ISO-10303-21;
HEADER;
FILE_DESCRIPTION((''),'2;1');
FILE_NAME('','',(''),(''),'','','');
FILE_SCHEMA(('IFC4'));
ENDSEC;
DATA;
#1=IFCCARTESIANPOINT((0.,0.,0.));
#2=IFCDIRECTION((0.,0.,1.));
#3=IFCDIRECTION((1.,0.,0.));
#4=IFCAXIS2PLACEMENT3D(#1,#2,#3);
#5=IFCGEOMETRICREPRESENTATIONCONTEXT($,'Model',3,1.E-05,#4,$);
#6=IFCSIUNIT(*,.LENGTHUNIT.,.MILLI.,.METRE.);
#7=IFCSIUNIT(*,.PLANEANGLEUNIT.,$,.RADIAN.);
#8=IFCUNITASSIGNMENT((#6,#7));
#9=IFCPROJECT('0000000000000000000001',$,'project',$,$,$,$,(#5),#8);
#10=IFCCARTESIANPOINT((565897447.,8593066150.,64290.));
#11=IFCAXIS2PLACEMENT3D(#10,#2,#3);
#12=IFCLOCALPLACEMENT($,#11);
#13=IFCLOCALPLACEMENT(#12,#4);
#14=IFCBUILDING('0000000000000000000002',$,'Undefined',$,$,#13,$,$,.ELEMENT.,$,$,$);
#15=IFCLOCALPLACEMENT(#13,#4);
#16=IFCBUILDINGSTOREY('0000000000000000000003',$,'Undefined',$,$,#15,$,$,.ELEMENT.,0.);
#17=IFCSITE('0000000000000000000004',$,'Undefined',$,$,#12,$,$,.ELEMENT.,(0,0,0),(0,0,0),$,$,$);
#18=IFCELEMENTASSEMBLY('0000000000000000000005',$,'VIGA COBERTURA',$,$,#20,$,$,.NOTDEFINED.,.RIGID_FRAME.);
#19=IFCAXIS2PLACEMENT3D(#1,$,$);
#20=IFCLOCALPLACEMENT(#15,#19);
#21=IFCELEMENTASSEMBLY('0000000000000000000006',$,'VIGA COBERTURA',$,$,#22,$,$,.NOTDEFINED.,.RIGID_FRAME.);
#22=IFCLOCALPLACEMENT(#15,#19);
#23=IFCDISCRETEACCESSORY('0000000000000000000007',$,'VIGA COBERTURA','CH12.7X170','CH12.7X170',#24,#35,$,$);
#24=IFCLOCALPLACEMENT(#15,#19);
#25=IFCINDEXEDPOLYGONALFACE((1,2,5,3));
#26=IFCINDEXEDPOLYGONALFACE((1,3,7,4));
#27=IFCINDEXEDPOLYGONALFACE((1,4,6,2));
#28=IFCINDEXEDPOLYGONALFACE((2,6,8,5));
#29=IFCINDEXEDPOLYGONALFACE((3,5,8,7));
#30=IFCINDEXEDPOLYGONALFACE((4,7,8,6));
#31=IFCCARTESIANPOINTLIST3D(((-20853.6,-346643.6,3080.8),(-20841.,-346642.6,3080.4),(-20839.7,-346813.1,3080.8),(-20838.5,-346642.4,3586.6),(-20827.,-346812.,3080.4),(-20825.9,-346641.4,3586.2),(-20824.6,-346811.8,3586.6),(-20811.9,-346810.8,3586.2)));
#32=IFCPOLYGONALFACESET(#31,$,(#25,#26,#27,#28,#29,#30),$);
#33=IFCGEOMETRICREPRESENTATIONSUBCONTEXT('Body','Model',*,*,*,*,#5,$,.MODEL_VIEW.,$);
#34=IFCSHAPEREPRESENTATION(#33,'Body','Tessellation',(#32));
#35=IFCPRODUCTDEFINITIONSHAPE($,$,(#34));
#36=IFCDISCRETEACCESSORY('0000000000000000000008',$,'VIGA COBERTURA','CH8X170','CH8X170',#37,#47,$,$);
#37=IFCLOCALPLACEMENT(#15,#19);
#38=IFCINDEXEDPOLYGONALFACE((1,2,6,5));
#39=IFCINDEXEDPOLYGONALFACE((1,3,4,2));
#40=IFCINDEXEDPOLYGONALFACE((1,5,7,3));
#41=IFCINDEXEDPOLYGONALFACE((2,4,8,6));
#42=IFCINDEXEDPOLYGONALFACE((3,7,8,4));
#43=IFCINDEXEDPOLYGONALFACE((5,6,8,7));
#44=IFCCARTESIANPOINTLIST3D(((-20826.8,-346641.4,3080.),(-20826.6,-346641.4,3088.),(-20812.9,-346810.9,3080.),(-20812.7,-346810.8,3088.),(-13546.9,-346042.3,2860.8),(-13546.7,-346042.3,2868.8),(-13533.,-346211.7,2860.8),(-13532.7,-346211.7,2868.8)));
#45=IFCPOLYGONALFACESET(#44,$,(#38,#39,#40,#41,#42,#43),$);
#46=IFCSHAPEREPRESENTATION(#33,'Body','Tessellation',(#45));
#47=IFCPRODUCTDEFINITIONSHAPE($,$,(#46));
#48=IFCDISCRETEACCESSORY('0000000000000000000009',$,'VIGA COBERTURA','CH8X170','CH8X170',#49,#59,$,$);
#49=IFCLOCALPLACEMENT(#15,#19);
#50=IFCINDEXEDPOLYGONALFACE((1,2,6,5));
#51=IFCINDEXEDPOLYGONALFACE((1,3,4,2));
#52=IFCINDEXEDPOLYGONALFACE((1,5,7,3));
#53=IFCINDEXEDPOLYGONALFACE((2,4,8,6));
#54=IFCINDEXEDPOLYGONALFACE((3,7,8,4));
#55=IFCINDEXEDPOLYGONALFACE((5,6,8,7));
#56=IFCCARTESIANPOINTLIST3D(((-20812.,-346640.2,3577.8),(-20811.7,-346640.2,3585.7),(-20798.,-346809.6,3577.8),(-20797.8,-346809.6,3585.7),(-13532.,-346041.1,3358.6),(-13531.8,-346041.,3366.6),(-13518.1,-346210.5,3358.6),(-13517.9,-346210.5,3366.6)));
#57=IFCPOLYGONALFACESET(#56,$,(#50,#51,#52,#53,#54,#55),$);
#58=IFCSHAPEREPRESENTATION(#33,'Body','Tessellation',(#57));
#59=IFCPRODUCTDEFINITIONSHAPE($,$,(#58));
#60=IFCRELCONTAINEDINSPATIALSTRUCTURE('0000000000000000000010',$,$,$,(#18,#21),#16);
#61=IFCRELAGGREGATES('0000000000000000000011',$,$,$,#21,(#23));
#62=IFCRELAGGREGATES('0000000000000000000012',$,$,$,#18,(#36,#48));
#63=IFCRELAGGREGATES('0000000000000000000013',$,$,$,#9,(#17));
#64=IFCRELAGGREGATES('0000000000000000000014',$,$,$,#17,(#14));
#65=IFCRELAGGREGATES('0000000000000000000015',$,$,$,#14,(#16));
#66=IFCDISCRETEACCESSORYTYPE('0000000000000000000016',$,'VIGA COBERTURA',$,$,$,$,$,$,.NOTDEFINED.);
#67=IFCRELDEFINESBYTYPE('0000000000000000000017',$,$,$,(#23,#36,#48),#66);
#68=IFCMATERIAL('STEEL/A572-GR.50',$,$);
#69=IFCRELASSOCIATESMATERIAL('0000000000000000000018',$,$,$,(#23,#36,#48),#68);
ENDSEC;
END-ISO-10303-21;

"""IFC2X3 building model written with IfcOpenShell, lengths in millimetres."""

from ifc_helpers import new_model, si_unit, frame, origin_with_axes, origin_2d_with_axis, place, context, subcontext, project, spatial, polyline, rectangle, outline, extrude, material, type_object, element, aggregate, save


model = new_model("IFC2X3")

# Units and contexts
model_context = context("Model", 3, precision=1e-05, world=origin_with_axes())
body_context = subcontext(model_context, "Body", "Model", "MODEL_VIEW")
ifc_project = project(units=[si_unit("LENGTHUNIT", "METRE", prefix="MILLI"), si_unit("PLANEANGLEUNIT", "RADIAN")], contexts=[model_context])

# Site, building, storey
site_placement = place(None, frame((565897447.0, 8593066150.0, 64290.0), z_axis=(0.0, 0.0, 1.0), x_axis=(1.0, 0.0, 0.0)))
site = spatial("IfcSite", under=ifc_project, at=site_placement, Name="Undefined", CompositionType="ELEMENT", RefLatitude=(0, 0, 0), RefLongitude=(0, 0, 0))
building_placement = place(site_placement, origin_with_axes())
building = spatial("IfcBuilding", under=site, at=building_placement, Name="Undefined", CompositionType="ELEMENT")
storey_placement = place(building_placement, origin_with_axes())
storey = spatial("IfcBuildingStorey", under=building, at=storey_placement, Name="Undefined", CompositionType="ELEMENT", Elevation=0.0)

# Element assemblies, discrete accessory
assembly_1_placement = place(storey_placement, origin_with_axes())
assembly_1 = element("IfcElementAssembly", 1, at=assembly_1_placement, inside=storey, Name="VIGA COBERTURA", AssemblyPlace="NOTDEFINED", PredefinedType="RIGID_FRAME")
ifc_material_1 = material(Name="STEEL/A572-GR.50")
discrete_accessory_type_1 = type_object("IfcDiscreteAccessoryType", Name="VIGA COBERTURA")
assembly_2_placement = place(storey_placement, origin_with_axes())
assembly_2 = element("IfcElementAssembly", 2, at=assembly_2_placement, inside=storey, Name="VIGA COBERTURA", AssemblyPlace="NOTDEFINED", PredefinedType="RIGID_FRAME")
discrete_accessory_1_placement = place(assembly_2_placement, frame((-20825.2, -346726.6, 3586.4), z_axis=(-0.082025, 0.99663, 0.0), x_axis=(-0.029885, -0.00246, -0.99955)))
discrete_accessory_1 = element("IfcDiscreteAccessory", 3, at=discrete_accessory_1_placement, type_object=discrete_accessory_type_1, material=ifc_material_1, Name="VIGA COBERTURA", Description="CH12.7X170", ObjectType="CH12.7X170", context=body_context, shape_type="SweptSolid", body=[
    extrude(rectangle(XDim=12.7, YDim=170.0, at=origin_2d_with_axis()), frame((506.0, 0.0, 0.0), z_axis=(-1.0, 0.0, 0.0), x_axis=(0.0, -1.0, 0.0)), (0.0, 0.0, 1.0), 506.0),
])

# Discrete accessories
discrete_accessory_2_placement = place(assembly_1_placement, frame((-20819.7, -346726.1, 3084.0), z_axis=(-0.029885, -0.00246, -0.99955), x_axis=(0.996182, 0.081989, -0.029987)))
discrete_accessory_2 = element("IfcDiscreteAccessory", 4, at=discrete_accessory_2_placement, type_object=discrete_accessory_type_1, material=ifc_material_1, Name="VIGA COBERTURA", Description="CH8X170", ObjectType="CH8X170", context=body_context, shape_type="SweptSolid", body=[
    extrude(outline(polyline([(0.0, -85.0), (0.0, 85.0), (7307.8, 85.0), (7307.8, -85.0), (0.0, -85.0)])), frame((0.0, 0.0, -4.0), z_axis=(0.0, 0.0, 1.0), x_axis=(1.0, 0.0, 0.0)), (0.0, 0.0, 1.0), 8.0),
])
aggregate(assembly_2, [discrete_accessory_1])
discrete_accessory_3_placement = place(assembly_1_placement, frame((-20804.9, -346724.9, 3581.7), z_axis=(-0.029885, -0.00246, -0.99955), x_axis=(0.996182, 0.081989, -0.029987)))
discrete_accessory_3 = element("IfcDiscreteAccessory", 5, at=discrete_accessory_3_placement, type_object=discrete_accessory_type_1, material=ifc_material_1, Name="VIGA COBERTURA", Description="CH8X170", ObjectType="CH8X170", context=body_context, shape_type="SweptSolid", body=[
    extrude(outline(polyline([(0.0, -85.0), (0.0, 85.0), (7307.8, 85.0), (7307.8, -85.0), (0.0, -85.0)])), frame((0.0, 0.0, -4.0), z_axis=(0.0, 0.0, 1.0), x_axis=(1.0, 0.0, 0.0)), (0.0, 0.0, 1.0), 8.0),
])
aggregate(assembly_1, [discrete_accessory_2, discrete_accessory_3])

save(model, "model.ifc")
